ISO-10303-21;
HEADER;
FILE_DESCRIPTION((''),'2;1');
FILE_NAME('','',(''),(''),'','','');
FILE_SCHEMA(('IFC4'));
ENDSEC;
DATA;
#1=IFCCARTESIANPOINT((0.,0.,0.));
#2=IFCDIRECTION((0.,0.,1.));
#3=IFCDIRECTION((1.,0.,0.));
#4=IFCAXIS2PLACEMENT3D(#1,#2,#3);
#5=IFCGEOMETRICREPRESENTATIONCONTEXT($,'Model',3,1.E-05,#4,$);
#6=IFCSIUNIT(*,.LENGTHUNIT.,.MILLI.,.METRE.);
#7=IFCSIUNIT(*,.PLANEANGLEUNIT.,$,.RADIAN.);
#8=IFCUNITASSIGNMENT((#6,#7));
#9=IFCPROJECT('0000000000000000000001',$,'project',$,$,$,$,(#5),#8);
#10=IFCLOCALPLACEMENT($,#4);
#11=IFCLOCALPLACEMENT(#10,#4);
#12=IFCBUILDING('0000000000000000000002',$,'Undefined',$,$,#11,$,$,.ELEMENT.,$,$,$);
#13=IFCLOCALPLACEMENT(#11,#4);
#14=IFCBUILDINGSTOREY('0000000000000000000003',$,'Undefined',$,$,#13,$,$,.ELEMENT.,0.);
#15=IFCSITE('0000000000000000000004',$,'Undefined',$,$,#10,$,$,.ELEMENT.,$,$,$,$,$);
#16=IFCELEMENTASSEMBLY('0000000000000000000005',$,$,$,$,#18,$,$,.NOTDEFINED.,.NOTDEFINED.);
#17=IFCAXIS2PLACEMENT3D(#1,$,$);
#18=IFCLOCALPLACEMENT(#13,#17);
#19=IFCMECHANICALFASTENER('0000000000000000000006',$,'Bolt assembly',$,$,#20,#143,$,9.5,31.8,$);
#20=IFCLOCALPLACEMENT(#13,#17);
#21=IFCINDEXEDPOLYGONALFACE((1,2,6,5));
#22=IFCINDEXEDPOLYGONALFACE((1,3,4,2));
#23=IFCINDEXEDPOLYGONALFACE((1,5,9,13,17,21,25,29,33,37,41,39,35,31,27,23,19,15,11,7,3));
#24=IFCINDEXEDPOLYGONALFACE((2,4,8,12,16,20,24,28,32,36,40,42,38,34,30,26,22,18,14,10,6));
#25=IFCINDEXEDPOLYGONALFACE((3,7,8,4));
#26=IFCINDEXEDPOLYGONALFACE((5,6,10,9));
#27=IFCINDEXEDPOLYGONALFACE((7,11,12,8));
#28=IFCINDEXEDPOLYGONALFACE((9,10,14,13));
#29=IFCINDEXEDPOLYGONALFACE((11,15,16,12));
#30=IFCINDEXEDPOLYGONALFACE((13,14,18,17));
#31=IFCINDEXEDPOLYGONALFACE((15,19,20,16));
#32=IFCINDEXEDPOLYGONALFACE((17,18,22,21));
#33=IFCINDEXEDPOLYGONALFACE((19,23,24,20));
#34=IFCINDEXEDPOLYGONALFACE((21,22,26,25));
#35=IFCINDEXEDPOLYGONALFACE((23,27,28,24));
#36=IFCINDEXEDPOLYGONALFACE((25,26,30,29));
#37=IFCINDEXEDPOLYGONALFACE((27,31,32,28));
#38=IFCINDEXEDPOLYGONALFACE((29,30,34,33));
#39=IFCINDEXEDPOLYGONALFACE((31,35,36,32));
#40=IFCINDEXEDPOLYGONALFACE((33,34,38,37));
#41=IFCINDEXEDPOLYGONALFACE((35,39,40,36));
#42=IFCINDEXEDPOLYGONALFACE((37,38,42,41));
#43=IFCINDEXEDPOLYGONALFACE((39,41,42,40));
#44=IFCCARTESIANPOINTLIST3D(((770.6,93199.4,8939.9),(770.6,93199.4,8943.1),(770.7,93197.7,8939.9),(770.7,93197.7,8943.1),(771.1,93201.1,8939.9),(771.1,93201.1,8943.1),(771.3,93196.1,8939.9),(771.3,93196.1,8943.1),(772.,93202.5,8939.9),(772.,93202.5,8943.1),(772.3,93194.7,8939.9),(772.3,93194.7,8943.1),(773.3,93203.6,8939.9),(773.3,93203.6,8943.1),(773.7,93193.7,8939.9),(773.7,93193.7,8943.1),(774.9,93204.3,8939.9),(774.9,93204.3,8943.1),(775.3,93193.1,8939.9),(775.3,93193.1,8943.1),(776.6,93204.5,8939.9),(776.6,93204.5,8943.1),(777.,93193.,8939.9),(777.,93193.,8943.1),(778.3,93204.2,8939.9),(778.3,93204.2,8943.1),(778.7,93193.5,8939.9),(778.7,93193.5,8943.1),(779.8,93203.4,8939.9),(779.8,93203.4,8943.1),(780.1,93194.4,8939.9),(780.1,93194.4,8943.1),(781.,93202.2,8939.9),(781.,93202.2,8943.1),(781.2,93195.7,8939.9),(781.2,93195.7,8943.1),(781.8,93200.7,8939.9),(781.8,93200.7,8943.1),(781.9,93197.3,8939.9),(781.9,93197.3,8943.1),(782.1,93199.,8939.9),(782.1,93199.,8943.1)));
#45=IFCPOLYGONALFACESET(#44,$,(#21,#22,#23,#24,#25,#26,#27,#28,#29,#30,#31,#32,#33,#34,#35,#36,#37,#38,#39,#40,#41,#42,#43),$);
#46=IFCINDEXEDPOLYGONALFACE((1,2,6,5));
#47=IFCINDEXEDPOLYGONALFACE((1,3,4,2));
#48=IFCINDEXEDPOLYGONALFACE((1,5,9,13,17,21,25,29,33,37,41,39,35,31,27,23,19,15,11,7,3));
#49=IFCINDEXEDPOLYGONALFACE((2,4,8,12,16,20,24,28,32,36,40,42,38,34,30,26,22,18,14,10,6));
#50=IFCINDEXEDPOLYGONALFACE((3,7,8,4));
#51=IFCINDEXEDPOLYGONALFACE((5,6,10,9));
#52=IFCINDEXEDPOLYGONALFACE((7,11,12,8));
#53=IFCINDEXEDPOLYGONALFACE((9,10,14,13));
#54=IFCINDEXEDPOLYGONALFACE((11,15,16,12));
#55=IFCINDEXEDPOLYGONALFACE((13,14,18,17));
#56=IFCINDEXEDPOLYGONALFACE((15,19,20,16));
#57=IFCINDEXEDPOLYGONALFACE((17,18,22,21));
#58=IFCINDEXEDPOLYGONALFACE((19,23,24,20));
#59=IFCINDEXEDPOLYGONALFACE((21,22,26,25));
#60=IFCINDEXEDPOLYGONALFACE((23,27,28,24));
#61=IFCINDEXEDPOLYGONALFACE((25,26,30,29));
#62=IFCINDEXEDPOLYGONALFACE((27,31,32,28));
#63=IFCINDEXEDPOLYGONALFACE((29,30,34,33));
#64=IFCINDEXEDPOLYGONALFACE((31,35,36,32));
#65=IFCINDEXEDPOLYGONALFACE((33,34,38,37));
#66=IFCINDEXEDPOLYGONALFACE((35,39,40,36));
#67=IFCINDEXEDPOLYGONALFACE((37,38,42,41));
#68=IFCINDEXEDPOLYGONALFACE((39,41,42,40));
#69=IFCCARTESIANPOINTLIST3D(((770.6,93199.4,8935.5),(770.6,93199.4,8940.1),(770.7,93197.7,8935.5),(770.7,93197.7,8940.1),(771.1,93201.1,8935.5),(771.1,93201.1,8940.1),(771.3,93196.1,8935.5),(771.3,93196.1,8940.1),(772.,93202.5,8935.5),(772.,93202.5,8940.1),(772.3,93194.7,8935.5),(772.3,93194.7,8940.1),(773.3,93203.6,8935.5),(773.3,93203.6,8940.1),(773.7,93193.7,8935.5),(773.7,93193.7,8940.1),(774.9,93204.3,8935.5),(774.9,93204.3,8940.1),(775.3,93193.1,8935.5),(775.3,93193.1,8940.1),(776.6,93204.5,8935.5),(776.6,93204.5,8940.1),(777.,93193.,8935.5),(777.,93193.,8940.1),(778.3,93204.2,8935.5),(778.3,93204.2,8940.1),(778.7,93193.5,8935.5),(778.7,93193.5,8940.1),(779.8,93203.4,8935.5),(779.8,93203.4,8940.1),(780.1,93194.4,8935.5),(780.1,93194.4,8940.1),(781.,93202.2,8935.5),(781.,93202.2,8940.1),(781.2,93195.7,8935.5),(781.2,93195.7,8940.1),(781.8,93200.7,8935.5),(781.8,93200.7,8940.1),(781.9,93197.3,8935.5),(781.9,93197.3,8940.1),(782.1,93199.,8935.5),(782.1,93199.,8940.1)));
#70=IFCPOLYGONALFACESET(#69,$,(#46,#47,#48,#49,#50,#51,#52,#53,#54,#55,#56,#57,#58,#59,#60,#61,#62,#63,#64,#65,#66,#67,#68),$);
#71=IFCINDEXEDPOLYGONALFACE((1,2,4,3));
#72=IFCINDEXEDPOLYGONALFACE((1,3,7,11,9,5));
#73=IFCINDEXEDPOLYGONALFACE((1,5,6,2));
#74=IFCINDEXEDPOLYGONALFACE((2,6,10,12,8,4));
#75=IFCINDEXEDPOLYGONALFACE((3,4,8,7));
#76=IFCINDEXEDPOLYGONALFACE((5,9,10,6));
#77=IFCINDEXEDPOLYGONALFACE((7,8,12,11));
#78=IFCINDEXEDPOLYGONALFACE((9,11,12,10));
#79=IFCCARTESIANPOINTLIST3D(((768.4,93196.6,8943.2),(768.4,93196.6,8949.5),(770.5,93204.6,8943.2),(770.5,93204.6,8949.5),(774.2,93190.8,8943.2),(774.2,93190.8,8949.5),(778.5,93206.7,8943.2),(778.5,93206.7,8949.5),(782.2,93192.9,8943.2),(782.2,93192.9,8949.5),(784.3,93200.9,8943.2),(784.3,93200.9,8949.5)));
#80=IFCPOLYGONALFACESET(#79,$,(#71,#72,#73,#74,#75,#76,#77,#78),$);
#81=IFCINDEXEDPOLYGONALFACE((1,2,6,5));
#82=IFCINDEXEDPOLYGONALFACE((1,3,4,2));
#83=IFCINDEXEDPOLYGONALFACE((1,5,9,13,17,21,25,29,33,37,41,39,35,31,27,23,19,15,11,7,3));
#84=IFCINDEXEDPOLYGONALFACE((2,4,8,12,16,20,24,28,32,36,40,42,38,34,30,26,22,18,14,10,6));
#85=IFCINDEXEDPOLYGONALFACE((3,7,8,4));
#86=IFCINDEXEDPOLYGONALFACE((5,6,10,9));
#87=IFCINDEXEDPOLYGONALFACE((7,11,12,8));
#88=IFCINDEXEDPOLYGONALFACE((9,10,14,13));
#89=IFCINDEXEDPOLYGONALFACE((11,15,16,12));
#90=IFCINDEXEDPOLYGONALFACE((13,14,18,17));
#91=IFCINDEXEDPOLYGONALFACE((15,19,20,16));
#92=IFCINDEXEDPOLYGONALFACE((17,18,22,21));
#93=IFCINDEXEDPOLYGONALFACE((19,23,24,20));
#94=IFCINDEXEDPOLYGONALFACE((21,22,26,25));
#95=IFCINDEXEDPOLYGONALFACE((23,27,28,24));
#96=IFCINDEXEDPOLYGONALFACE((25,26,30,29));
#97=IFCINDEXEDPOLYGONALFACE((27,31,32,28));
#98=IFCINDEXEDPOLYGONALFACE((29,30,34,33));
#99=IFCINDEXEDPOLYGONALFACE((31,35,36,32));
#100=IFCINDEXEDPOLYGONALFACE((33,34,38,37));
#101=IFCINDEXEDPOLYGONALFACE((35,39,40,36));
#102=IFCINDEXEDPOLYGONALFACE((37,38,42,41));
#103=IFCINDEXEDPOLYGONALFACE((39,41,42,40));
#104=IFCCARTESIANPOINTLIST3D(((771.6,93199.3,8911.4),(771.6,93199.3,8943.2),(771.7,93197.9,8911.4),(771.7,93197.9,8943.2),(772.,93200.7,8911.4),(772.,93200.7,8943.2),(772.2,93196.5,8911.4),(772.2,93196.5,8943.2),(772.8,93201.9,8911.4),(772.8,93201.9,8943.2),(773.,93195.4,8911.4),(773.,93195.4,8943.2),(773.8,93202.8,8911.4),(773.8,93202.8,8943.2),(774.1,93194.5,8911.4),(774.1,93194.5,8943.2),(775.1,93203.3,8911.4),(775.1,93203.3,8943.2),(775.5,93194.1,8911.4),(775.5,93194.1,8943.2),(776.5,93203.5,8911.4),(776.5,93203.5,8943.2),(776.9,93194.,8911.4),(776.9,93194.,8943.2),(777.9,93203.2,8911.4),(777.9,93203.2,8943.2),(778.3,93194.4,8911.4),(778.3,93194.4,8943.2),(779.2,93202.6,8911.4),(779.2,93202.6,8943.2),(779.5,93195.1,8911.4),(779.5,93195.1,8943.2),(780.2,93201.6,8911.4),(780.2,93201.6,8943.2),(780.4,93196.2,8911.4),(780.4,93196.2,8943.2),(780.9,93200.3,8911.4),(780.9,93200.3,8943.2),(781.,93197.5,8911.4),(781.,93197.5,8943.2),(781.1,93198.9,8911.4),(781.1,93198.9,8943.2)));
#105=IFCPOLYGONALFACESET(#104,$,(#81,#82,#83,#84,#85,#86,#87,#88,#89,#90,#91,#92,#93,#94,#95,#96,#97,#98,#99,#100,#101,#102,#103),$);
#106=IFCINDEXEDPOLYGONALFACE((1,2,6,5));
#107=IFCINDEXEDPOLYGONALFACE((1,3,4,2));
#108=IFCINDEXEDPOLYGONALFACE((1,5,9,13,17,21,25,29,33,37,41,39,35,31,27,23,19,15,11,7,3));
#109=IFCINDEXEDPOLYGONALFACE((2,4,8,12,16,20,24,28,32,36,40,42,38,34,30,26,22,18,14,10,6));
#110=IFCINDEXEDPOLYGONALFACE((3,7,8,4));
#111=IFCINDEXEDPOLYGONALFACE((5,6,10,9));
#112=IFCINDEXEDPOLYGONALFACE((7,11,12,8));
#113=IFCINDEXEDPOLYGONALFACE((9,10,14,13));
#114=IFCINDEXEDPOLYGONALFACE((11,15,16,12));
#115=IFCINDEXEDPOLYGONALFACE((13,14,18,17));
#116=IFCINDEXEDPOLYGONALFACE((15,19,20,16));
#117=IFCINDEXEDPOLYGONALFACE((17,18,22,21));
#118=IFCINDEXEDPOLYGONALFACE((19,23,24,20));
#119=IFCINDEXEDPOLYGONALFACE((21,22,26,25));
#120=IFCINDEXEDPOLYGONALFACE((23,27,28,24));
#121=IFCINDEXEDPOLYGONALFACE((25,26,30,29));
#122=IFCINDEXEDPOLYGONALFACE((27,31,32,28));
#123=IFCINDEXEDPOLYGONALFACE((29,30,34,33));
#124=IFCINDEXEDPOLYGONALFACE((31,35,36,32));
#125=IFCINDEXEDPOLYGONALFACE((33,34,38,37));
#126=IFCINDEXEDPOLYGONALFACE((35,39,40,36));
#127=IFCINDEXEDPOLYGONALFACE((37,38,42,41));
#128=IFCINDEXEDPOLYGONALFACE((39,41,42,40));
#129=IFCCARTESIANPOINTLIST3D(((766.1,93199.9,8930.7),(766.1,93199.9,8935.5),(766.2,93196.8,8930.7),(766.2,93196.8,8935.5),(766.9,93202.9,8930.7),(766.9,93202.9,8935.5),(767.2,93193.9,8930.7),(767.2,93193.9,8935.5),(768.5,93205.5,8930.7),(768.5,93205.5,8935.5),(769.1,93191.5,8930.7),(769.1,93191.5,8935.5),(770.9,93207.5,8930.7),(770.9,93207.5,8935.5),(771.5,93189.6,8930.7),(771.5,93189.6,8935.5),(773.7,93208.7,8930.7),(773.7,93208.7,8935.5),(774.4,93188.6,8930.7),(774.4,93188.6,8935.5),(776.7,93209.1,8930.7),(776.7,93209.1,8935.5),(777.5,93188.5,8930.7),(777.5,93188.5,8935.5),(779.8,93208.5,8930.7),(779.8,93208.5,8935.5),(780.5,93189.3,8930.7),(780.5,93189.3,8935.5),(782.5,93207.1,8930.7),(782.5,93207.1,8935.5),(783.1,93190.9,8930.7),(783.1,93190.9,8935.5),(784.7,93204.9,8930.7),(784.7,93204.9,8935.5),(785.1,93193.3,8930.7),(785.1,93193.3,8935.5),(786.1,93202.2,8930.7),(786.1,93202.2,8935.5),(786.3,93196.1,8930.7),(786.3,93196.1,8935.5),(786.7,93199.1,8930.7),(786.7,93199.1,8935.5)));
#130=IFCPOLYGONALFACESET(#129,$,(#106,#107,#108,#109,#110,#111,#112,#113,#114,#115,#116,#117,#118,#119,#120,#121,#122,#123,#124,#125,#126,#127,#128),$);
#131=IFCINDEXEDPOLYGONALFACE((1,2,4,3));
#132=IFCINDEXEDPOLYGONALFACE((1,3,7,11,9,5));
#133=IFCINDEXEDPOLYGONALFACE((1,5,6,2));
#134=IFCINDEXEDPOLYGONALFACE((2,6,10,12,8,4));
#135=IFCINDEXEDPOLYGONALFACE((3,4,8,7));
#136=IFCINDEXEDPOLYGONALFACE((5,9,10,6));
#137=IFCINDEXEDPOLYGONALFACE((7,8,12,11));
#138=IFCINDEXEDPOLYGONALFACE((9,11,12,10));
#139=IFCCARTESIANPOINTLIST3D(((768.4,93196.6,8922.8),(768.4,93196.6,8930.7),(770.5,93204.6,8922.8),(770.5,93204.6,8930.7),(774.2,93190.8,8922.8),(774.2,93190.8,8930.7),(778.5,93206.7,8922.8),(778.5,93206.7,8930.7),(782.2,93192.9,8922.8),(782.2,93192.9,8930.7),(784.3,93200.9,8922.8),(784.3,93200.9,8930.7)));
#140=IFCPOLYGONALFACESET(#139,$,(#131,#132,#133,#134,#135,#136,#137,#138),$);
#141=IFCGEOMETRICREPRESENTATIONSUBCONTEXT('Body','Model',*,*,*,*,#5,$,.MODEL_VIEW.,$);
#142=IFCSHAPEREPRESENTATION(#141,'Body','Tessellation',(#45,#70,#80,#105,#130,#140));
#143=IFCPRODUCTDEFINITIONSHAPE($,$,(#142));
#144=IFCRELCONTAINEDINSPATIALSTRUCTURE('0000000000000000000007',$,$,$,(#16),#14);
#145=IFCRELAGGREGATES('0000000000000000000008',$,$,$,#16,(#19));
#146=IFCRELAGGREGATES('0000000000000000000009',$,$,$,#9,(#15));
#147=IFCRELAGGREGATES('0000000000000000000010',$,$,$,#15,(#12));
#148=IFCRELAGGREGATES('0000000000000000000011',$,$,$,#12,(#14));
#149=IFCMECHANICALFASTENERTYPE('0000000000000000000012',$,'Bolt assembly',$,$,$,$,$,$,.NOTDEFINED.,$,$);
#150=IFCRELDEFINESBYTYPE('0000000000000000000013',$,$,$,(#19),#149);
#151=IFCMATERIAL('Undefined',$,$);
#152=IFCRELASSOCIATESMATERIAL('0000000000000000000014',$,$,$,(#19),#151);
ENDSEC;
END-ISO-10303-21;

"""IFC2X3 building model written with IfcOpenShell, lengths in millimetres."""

from ifc_helpers import new_model, si_unit, frame, origin_with_axes, origin_2d_with_axis, place, context, subcontext, project, spatial, polyline, circle, outline, extrude, source, transform, mapped, material, type_object, element, aggregate, save


model = new_model("IFC2X3")

# Units and contexts
model_context = context("Model", 3, precision=1e-05, world=origin_with_axes())
body_context = subcontext(model_context, "Body", "Model", "MODEL_VIEW")
ifc_project = project(units=[si_unit("LENGTHUNIT", "METRE", prefix="MILLI"), si_unit("PLANEANGLEUNIT", "RADIAN")], contexts=[model_context])

# Site, building, storey
site_placement = place(None, origin_with_axes())
site = spatial("IfcSite", under=ifc_project, at=site_placement, Name="Undefined", CompositionType="ELEMENT")
building_placement = place(site_placement, origin_with_axes())
building = spatial("IfcBuilding", under=site, at=building_placement, Name="Undefined", CompositionType="ELEMENT")
storey_placement = place(building_placement, origin_with_axes())
storey = spatial("IfcBuildingStorey", under=building, at=storey_placement, Name="Undefined", CompositionType="ELEMENT", Elevation=0.0)

# Shared definitions
ifc_material_1 = material(Name="Undefined")
mechanical_fastener_type = type_object("IfcMechanicalFastenerType", Name="Bolt assembly")

# Element assembly, mechanical fastener
assembly_1_placement = place(storey_placement, origin_with_axes())
assembly_1 = element("IfcElementAssembly", 1, at=assembly_1_placement, inside=storey, AssemblyPlace="NOTDEFINED", PredefinedType="NOTDEFINED")
shared_shape_1 = source(origin_with_axes(), body_context, "Body", "SweptSolid", [
    extrude(circle(Radius=5.8, at=origin_2d_with_axis()), frame((0.0, -7.6, 0.0), z_axis=(0.0, 1.0, 0.0), x_axis=(1.0, 0.0, 0.0)), (0.0, 0.0, 1.0), 3.2),
    extrude(circle(Radius=5.8, at=origin_2d_with_axis()), frame((0.0, -4.6, 0.0), z_axis=(0.0, 1.0, 0.0), x_axis=(1.0, 0.0, 0.0)), (0.0, 0.0, 1.0), 4.6),
    extrude(outline(polyline([(7.1, -4.1), (7.1, 4.1), (0.0, 8.2), (-7.1, 4.1), (-7.1, -4.1), (0.0, -8.2), (7.1, -4.1)])), frame((0.0, -14.0, 0.0), z_axis=(0.0, 1.0, 0.0), x_axis=(1.0, 0.0, 0.0)), (0.0, 0.0, 1.0), 6.3),
    extrude(circle(Radius=4.8, at=origin_2d_with_axis()), frame((0.0, -7.7, 0.0), z_axis=(0.0, 1.0, 0.0), x_axis=(1.0, 0.0, 0.0)), (0.0, 0.0, 1.0), 31.8),
    extrude(circle(Radius=10.3, at=origin_2d_with_axis()), frame((0.0, 0.0, 0.0), z_axis=(0.0, 1.0, 0.0), x_axis=(1.0, 0.0, 0.0)), (0.0, 0.0, 1.0), 4.8),
    extrude(outline(polyline([(7.1, -4.1), (7.1, 4.1), (0.0, 8.2), (-7.1, 4.1), (-7.1, -4.1), (0.0, -8.2), (7.1, -4.1)])), frame((0.0, 4.8, 0.0), z_axis=(0.0, 1.0, 0.0), x_axis=(1.0, 0.0, 0.0)), (0.0, 0.0, 1.0), 7.9),
])
mechanical_fastener_1_placement = place(assembly_1_placement, frame((776.4, 93198.7, 8935.5), z_axis=(0.707107, -0.707107, 0.0), x_axis=(-0.707107, -0.707107, 0.0)))
mechanical_fastener_1 = element("IfcMechanicalFastener", 2, at=mechanical_fastener_1_placement, type_object=mechanical_fastener_type, material=ifc_material_1, Name="Bolt assembly", NominalDiameter=9.5, NominalLength=31.8, context=body_context, shape_type="MappedRepresentation", body=[
    mapped(shared_shape_1, transform((0.0, 0.0, 0.0))),
])
aggregate(assembly_1, [mechanical_fastener_1])

save(model, "model.ifc")
